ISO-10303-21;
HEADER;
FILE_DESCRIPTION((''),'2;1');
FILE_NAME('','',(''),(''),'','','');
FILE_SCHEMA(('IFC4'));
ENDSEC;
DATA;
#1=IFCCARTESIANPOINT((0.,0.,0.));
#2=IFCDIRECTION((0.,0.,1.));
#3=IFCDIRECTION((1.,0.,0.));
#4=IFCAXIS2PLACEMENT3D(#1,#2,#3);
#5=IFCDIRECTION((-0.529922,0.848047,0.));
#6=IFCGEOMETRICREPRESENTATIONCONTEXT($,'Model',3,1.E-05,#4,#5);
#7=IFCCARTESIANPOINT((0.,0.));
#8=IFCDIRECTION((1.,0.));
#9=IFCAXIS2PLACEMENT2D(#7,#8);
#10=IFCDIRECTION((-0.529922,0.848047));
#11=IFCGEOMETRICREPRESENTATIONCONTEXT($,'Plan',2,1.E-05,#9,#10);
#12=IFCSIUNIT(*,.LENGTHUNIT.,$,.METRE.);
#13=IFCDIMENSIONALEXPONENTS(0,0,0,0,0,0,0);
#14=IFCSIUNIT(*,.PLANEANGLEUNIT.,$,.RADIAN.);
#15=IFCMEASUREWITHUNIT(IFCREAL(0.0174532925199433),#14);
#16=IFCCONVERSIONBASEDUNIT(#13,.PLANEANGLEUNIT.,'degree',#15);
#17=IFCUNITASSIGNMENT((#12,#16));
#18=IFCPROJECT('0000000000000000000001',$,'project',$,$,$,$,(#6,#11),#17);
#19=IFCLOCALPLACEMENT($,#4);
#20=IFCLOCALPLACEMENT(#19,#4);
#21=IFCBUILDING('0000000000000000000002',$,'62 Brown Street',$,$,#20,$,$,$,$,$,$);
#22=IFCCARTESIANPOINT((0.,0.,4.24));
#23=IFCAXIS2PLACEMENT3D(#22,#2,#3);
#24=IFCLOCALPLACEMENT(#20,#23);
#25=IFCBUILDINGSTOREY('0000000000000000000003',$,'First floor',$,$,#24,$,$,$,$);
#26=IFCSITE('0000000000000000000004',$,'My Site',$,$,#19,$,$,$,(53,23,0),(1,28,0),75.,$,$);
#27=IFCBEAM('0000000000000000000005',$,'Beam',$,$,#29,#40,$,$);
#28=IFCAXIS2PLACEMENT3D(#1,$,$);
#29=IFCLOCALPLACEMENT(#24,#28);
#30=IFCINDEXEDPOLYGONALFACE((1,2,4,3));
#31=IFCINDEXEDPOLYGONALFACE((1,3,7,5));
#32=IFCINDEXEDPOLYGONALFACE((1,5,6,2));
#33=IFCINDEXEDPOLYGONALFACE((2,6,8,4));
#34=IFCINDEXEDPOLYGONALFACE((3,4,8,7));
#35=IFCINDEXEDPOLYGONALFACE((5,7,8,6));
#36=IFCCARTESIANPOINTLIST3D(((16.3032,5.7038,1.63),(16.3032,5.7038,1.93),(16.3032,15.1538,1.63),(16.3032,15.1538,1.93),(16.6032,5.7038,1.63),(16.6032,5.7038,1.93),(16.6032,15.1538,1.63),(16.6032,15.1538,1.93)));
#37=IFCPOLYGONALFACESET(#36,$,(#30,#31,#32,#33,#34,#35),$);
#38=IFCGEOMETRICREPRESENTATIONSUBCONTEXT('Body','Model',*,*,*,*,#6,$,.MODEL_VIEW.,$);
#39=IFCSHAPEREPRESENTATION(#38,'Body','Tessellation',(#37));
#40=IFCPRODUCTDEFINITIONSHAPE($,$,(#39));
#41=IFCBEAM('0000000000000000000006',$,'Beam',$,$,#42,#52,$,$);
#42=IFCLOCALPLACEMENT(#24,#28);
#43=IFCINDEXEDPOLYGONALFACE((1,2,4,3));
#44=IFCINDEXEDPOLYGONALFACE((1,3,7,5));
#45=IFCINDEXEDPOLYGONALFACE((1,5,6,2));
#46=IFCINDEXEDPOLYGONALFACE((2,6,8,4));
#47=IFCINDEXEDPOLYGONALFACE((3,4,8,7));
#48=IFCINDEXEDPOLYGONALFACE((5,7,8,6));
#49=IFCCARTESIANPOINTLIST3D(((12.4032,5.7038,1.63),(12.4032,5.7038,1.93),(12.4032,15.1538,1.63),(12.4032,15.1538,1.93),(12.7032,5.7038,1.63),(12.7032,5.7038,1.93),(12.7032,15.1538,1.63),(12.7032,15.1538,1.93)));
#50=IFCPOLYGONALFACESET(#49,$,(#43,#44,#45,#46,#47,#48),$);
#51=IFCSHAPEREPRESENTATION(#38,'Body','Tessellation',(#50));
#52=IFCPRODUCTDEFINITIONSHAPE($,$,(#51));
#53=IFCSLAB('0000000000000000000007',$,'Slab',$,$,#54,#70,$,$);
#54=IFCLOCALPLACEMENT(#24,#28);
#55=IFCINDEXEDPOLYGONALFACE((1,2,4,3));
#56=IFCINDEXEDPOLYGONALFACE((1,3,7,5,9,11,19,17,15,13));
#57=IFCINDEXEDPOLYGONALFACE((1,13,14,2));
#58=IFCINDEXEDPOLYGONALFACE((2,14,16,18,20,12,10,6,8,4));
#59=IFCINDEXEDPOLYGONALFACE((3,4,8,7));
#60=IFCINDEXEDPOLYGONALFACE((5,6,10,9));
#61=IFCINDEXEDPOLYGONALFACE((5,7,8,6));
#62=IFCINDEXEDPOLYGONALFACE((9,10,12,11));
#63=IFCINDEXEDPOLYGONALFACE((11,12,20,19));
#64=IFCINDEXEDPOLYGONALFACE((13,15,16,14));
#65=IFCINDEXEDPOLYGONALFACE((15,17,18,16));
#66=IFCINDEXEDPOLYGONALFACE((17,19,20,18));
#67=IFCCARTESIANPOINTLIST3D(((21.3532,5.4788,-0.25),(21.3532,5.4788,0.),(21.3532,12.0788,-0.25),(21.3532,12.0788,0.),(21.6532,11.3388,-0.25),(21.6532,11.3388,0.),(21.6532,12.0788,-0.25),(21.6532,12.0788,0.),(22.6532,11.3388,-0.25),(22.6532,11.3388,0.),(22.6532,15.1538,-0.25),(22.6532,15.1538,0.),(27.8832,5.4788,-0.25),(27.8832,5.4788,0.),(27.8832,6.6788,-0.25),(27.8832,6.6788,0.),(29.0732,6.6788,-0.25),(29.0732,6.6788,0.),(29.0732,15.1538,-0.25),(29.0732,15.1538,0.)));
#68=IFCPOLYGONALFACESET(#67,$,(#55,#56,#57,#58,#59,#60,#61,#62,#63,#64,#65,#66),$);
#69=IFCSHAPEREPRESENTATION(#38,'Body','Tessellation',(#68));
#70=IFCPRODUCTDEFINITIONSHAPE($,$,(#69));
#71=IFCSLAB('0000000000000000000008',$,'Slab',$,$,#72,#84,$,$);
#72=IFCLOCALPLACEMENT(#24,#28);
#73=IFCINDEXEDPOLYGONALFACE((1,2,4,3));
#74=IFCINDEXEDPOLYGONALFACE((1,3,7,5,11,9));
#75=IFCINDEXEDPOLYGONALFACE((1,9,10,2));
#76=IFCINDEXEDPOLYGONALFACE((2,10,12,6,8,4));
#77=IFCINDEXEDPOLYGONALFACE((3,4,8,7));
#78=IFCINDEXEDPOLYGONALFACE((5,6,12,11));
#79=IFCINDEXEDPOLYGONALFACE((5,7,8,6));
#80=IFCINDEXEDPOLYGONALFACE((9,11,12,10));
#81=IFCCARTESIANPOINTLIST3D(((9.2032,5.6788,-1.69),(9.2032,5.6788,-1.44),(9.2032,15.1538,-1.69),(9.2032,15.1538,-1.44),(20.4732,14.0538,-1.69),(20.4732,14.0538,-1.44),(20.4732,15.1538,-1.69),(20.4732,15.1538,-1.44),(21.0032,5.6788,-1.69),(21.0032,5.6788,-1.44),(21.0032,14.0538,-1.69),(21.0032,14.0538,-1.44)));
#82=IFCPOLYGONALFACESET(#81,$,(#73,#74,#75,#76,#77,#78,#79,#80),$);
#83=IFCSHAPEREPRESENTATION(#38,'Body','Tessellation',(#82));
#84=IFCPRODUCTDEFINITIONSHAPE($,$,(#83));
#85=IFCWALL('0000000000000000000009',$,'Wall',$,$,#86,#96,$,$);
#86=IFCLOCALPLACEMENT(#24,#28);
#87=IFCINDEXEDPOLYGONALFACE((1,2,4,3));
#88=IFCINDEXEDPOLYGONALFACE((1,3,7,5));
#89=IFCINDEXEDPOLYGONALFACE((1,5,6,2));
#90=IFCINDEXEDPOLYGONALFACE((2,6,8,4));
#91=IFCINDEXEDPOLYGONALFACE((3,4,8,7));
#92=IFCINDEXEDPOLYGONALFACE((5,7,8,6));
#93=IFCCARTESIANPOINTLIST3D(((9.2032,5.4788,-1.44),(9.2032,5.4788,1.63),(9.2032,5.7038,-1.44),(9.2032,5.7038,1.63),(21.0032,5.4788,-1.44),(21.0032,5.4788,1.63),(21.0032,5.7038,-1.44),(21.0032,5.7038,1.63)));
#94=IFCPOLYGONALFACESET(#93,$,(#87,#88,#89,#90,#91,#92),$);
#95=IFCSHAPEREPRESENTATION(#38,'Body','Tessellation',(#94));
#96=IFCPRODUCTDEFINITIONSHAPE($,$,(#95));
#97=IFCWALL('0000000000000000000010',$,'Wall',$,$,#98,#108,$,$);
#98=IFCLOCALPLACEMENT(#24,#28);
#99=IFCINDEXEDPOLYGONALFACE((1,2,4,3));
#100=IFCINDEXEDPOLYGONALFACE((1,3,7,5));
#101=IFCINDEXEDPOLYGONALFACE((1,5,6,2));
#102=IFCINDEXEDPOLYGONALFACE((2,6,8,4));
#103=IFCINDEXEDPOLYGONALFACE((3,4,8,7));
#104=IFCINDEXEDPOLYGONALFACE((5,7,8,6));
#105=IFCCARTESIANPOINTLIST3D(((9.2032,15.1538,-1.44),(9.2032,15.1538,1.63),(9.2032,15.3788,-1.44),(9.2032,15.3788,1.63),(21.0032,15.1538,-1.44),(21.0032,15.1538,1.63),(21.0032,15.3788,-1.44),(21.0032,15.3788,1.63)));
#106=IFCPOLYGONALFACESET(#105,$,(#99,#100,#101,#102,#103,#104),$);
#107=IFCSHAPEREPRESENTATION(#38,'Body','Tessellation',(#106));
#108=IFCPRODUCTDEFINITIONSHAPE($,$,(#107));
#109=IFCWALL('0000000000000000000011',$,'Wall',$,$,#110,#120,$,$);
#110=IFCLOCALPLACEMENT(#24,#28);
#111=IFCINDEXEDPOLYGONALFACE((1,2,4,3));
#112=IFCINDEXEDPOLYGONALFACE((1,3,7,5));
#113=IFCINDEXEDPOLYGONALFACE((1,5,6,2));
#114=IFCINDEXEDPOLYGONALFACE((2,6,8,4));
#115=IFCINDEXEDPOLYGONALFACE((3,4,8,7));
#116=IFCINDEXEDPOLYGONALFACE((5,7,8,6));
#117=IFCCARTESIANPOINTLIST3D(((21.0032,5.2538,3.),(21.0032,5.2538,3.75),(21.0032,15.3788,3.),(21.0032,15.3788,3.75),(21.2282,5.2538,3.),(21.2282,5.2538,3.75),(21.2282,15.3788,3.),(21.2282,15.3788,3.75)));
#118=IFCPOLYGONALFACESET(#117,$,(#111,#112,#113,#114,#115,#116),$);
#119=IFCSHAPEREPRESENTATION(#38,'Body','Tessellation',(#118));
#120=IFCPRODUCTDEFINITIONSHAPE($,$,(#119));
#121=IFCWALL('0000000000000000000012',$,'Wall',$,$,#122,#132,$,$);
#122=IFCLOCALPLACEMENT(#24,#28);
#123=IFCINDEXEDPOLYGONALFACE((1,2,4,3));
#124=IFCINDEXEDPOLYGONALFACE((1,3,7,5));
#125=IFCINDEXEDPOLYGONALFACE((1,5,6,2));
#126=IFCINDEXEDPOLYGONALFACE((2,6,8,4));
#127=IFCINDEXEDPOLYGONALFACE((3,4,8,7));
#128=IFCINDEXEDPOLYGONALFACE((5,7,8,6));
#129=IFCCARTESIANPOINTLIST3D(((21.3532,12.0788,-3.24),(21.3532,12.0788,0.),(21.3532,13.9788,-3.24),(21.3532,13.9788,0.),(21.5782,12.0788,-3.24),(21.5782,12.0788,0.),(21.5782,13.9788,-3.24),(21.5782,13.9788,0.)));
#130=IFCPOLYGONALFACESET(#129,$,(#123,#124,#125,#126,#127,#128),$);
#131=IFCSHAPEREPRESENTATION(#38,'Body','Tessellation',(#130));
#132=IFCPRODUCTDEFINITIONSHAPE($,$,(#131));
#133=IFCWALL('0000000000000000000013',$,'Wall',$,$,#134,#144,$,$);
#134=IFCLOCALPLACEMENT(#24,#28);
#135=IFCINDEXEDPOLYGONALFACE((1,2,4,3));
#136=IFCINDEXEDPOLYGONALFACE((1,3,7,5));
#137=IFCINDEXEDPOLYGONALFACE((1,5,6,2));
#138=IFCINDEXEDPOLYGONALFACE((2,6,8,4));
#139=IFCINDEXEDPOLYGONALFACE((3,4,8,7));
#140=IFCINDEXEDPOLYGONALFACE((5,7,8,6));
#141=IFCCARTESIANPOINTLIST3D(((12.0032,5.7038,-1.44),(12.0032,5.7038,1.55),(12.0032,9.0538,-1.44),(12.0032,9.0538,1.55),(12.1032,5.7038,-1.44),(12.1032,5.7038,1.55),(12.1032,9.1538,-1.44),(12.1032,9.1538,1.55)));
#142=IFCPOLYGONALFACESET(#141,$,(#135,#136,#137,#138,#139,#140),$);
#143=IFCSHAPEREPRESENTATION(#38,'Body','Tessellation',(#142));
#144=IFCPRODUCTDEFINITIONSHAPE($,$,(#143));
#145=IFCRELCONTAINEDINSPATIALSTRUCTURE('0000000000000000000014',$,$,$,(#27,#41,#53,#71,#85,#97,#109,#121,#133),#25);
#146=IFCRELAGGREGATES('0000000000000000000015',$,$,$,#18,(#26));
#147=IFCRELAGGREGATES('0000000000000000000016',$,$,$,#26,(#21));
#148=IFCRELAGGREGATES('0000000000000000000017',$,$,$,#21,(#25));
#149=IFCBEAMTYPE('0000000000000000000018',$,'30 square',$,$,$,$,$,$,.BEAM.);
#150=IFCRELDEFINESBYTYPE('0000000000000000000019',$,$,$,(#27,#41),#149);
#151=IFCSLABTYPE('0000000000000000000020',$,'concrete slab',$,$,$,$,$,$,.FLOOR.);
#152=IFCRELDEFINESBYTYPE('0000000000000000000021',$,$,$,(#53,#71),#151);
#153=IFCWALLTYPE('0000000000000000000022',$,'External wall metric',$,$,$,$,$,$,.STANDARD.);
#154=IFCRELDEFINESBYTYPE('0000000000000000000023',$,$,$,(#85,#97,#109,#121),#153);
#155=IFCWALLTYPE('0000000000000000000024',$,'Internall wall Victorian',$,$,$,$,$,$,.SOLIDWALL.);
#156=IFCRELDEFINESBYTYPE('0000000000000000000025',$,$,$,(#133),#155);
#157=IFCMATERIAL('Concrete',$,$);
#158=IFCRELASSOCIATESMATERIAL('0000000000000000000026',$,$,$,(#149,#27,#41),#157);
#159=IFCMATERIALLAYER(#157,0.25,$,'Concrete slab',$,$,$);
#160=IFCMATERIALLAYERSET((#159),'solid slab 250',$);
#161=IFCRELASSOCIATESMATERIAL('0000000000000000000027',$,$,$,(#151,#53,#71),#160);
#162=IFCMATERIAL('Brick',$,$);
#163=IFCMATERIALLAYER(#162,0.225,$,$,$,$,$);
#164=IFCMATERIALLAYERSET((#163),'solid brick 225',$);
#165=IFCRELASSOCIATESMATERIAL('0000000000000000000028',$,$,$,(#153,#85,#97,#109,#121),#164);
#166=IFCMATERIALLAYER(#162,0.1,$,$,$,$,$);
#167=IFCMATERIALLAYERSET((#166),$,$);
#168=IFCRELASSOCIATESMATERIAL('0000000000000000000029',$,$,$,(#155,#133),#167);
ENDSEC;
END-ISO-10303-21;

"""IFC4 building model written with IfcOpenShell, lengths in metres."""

from ifc_helpers import new_model, entity, si_unit, converted_unit, direction, frame, origin_with_axes, origin_2d_with_axis, place, context, subcontext, project, spatial, line, indexed_curve, rectangle, outline, extrude, clip, halfspace, material, layer, layer_set, layer_usage, material_profile, profile_set, profile_usage, type_object, element, save


model = new_model("IFC4")

# Units and contexts
model_context = context("Model", 3, precision=1e-05, world=origin_with_axes(), true_north=direction((-0.529922, 0.848047, 0.0)))
plan_context = context("Plan", 2, precision=1e-05, world=origin_2d_with_axis(), true_north=direction((-0.529922, 0.848047)))
body_context_1 = subcontext(model_context, "Body", "Model", "MODEL_VIEW")
ifc_project = project(units=[si_unit("LENGTHUNIT", "METRE"), converted_unit("PLANEANGLEUNIT", "degree", entity("IfcReal", 0.0174532925199433), si_unit("PLANEANGLEUNIT", "RADIAN"), dimensions=[0, 0, 0, 0, 0, 0, 0])], contexts=[model_context, plan_context])

# Site, building, storey
site_placement = place(None, origin_with_axes())
site = spatial("IfcSite", under=ifc_project, at=site_placement, Name="My Site", RefLatitude=(53, 23, 0), RefLongitude=(1, 28, 0), RefElevation=75.0)
building_placement = place(site_placement, origin_with_axes())
building = spatial("IfcBuilding", under=site, at=building_placement, Name="62 Brown Street")
storey_placement = place(building_placement, frame((0.0, 0.0, 4.24), z_axis=(0.0, 0.0, 1.0), x_axis=(1.0, 0.0, 0.0)))
storey = spatial("IfcBuildingStorey", under=building, at=storey_placement, Name="First floor")

# Shared definitions
ifc_material_1 = material(Name="Concrete")

# Beams
ifc_material_profile_1 = material_profile(ifc_material_1, rectangle(XDim=0.3, YDim=0.3))
ifc_profile_set_1 = profile_set([ifc_material_profile_1])
beam_type = type_object("IfcBeamType", Name="30 square", PredefinedType="BEAM", material=ifc_profile_set_1)
ifc_profile_usage_1 = profile_usage(ifc_profile_set_1, cardinal=5)
beam_1_placement = place(storey_placement, frame((16.4532, 15.1538, 1.78), z_axis=(0.0, -1.0, 0.0), x_axis=(1.0, 0.0, 0.0)))
element("IfcBeam", 1, at=beam_1_placement, inside=storey, type_object=beam_type, material=ifc_profile_usage_1, Name="Beam", context=body_context_1, shape_type="SweptSolid", body=[
    extrude(rectangle(XDim=0.3, YDim=0.3), origin_with_axes(), (0.0, 0.0, 1.0), 9.45),
])
ifc_profile_usage_2 = profile_usage(ifc_profile_set_1, cardinal=5)
beam_2_placement = place(storey_placement, frame((12.5532, 15.1538, 1.78), z_axis=(0.0, -1.0, 0.0), x_axis=(1.0, 0.0, 0.0)))
element("IfcBeam", 2, at=beam_2_placement, inside=storey, type_object=beam_type, material=ifc_profile_usage_2, Name="Beam", context=body_context_1, shape_type="SweptSolid", body=[
    extrude(rectangle(XDim=0.3, YDim=0.3), origin_with_axes(), (0.0, 0.0, 1.0), 9.45),
])

# Slabs
ifc_layer_1 = layer(ifc_material_1, 0.25, Name="Concrete slab")
ifc_layer_set_1 = layer_set([ifc_layer_1], Name="solid slab 250")
ifc_layer_usage_1 = layer_usage(ifc_layer_set_1, "AXIS3", "POSITIVE", 0.0)
slab_type = type_object("IfcSlabType", Name="concrete slab", PredefinedType="FLOOR", material=ifc_layer_set_1)
slab_1_placement = place(storey_placement, frame((21.3532, 5.4788, -0.25), z_axis=(0.0, 0.0, 1.0), x_axis=(1.0, 0.0, 0.0)))
element("IfcSlab", 3, at=slab_1_placement, inside=storey, type_object=slab_type, material=ifc_layer_usage_1, Name="Slab", context=body_context_1, shape_type="SweptSolid", body=[
    extrude(outline(indexed_curve([(6.53, 1.2), (6.53, 0.0), (0.0, 0.0), (0.0, 6.6), (0.3, 6.6), (0.3, 5.86), (1.3, 5.86), (1.3, 9.675), (7.72, 9.675), (7.72, 1.2), (6.53, 1.2)])), None, (0.0, 0.0, 1.0), 0.25),
])
ifc_layer_usage_2 = layer_usage(ifc_layer_set_1, "AXIS3", "POSITIVE", 0.0)
slab_2_placement = place(storey_placement, frame((9.2032, 5.6788, -1.69), z_axis=(0.0, 0.0, 1.0), x_axis=(1.0, 0.0, 0.0)))
element("IfcSlab", 4, at=slab_2_placement, inside=storey, type_object=slab_type, material=ifc_layer_usage_2, Name="Slab", context=body_context_1, shape_type="SweptSolid", body=[
    extrude(outline(indexed_curve([(11.27, 9.475), (11.8, 0.0), (0.0, 0.0), (0.0, 9.475), (11.8, 8.375), (11.27, 8.375)], segments=[line(6, 1), line(1, 4), line(4, 3), line(3, 2), line(2, 5), line(5, 6)], self_intersect=False)), None, (0.0, 0.0, 1.0), 0.25),
])

# Walls
ifc_material_2 = material(Name="Brick")
ifc_layer_2 = layer(ifc_material_2, 0.225)
ifc_layer_set_2 = layer_set([ifc_layer_2], Name="solid brick 225")
ifc_layer_usage_3 = layer_usage(ifc_layer_set_2, "AXIS2", "POSITIVE", 0.0)
wall_type_1 = type_object("IfcWallType", Name="External wall metric", PredefinedType="STANDARD", material=ifc_layer_set_2)
wall_1_placement = place(storey_placement, frame((9.2032, 5.4788, -1.44), z_axis=(0.0, 0.0, 1.0), x_axis=(1.0, 0.0, 0.0)))
element("IfcWall", 5, at=wall_1_placement, inside=storey, type_object=wall_type_1, material=ifc_layer_usage_3, Name="Wall", context=body_context_1, shape_type="SweptSolid", body=[
    extrude(outline(indexed_curve([(0.0, 0.0), (0.0, 0.225), (11.8, 0.225), (11.8, 0.0), (0.0, 0.0)], self_intersect=False)), origin_with_axes(), (0.0, 0.0, 1.0), 3.07),
])
ifc_layer_usage_4 = layer_usage(ifc_layer_set_2, "AXIS2", "POSITIVE", 0.0)
wall_2_placement = place(storey_placement, frame((21.0032, 15.3788, -1.44), z_axis=(0.0, 0.0, 1.0), x_axis=(-1.0, 0.0, 0.0)))
element("IfcWall", 6, at=wall_2_placement, inside=storey, type_object=wall_type_1, material=ifc_layer_usage_4, Name="Wall", context=body_context_1, shape_type="SweptSolid", body=[
    extrude(outline(indexed_curve([(0.0, 0.0), (0.0, 0.225), (11.8, 0.225), (11.8, 0.0), (0.0, 0.0)], self_intersect=False)), origin_with_axes(), (0.0, 0.0, 1.0), 3.07),
])
ifc_layer_usage_5 = layer_usage(ifc_layer_set_2, "AXIS2", "POSITIVE", 0.0)
wall_3_placement = place(storey_placement, frame((21.0032, 15.3788, 3.0), z_axis=(0.0, 0.0, 1.0), x_axis=(0.0, -1.0, 0.0)))
element("IfcWall", 7, at=wall_3_placement, inside=storey, type_object=wall_type_1, material=ifc_layer_usage_5, Name="Wall", context=body_context_1, shape_type="SweptSolid", body=[
    extrude(outline(indexed_curve([(0.0, 0.0), (0.0, 0.225), (10.125, 0.225), (10.125, 0.0), (0.0, 0.0)], self_intersect=False)), origin_with_axes(), (0.0, 0.0, 1.0), 0.75),
])
ifc_layer_usage_6 = layer_usage(ifc_layer_set_2, "AXIS2", "POSITIVE", 0.0)
wall_4_placement = place(storey_placement, frame((21.3532, 13.9788, -3.24), z_axis=(0.0, 0.0, 1.0), x_axis=(0.0, -1.0, 0.0)))
element("IfcWall", 8, at=wall_4_placement, inside=storey, type_object=wall_type_1, material=ifc_layer_usage_6, Name="Wall", context=body_context_1, shape_type="SweptSolid", body=[
    extrude(outline(indexed_curve([(0.0, 0.0), (0.0, 0.225), (1.9, 0.225), (1.9, 0.0), (0.0, 0.0)], self_intersect=False)), origin_with_axes(), (0.0, 0.0, 1.0), 3.24),
])
ifc_layer_3 = layer(ifc_material_2, 0.1)
ifc_layer_set_3 = layer_set([ifc_layer_3])
ifc_layer_usage_7 = layer_usage(ifc_layer_set_3, "AXIS2", "POSITIVE", 0.0)
wall_type_2 = type_object("IfcWallType", Name="Internall wall Victorian", PredefinedType="SOLIDWALL", material=ifc_layer_set_3)
wall_5_placement = place(storey_placement, frame((12.1032, 5.7038, -1.44), z_axis=(0.0, 0.0, 1.0), x_axis=(0.0, 1.0, 0.0)))
element("IfcWall", 9, at=wall_5_placement, inside=storey, type_object=wall_type_2, material=ifc_layer_usage_7, Name="Wall", context=body_context_1, shape_type="Clipping", body=[
    clip(extrude(outline(indexed_curve([(0.0, 0.0), (0.0, 0.1), (3.45, 0.1), (3.45, 0.0), (0.0, 0.0)], self_intersect=False)), origin_with_axes(), (0.0, 0.0, 1.0), 2.99), halfspace(frame((3.45, 0.0, -2.8), z_axis=(0.707107, 0.707107, 0.0), x_axis=(0.707107, -0.707107, 0.0)), False)),
])

save(model, "model.ifc")
